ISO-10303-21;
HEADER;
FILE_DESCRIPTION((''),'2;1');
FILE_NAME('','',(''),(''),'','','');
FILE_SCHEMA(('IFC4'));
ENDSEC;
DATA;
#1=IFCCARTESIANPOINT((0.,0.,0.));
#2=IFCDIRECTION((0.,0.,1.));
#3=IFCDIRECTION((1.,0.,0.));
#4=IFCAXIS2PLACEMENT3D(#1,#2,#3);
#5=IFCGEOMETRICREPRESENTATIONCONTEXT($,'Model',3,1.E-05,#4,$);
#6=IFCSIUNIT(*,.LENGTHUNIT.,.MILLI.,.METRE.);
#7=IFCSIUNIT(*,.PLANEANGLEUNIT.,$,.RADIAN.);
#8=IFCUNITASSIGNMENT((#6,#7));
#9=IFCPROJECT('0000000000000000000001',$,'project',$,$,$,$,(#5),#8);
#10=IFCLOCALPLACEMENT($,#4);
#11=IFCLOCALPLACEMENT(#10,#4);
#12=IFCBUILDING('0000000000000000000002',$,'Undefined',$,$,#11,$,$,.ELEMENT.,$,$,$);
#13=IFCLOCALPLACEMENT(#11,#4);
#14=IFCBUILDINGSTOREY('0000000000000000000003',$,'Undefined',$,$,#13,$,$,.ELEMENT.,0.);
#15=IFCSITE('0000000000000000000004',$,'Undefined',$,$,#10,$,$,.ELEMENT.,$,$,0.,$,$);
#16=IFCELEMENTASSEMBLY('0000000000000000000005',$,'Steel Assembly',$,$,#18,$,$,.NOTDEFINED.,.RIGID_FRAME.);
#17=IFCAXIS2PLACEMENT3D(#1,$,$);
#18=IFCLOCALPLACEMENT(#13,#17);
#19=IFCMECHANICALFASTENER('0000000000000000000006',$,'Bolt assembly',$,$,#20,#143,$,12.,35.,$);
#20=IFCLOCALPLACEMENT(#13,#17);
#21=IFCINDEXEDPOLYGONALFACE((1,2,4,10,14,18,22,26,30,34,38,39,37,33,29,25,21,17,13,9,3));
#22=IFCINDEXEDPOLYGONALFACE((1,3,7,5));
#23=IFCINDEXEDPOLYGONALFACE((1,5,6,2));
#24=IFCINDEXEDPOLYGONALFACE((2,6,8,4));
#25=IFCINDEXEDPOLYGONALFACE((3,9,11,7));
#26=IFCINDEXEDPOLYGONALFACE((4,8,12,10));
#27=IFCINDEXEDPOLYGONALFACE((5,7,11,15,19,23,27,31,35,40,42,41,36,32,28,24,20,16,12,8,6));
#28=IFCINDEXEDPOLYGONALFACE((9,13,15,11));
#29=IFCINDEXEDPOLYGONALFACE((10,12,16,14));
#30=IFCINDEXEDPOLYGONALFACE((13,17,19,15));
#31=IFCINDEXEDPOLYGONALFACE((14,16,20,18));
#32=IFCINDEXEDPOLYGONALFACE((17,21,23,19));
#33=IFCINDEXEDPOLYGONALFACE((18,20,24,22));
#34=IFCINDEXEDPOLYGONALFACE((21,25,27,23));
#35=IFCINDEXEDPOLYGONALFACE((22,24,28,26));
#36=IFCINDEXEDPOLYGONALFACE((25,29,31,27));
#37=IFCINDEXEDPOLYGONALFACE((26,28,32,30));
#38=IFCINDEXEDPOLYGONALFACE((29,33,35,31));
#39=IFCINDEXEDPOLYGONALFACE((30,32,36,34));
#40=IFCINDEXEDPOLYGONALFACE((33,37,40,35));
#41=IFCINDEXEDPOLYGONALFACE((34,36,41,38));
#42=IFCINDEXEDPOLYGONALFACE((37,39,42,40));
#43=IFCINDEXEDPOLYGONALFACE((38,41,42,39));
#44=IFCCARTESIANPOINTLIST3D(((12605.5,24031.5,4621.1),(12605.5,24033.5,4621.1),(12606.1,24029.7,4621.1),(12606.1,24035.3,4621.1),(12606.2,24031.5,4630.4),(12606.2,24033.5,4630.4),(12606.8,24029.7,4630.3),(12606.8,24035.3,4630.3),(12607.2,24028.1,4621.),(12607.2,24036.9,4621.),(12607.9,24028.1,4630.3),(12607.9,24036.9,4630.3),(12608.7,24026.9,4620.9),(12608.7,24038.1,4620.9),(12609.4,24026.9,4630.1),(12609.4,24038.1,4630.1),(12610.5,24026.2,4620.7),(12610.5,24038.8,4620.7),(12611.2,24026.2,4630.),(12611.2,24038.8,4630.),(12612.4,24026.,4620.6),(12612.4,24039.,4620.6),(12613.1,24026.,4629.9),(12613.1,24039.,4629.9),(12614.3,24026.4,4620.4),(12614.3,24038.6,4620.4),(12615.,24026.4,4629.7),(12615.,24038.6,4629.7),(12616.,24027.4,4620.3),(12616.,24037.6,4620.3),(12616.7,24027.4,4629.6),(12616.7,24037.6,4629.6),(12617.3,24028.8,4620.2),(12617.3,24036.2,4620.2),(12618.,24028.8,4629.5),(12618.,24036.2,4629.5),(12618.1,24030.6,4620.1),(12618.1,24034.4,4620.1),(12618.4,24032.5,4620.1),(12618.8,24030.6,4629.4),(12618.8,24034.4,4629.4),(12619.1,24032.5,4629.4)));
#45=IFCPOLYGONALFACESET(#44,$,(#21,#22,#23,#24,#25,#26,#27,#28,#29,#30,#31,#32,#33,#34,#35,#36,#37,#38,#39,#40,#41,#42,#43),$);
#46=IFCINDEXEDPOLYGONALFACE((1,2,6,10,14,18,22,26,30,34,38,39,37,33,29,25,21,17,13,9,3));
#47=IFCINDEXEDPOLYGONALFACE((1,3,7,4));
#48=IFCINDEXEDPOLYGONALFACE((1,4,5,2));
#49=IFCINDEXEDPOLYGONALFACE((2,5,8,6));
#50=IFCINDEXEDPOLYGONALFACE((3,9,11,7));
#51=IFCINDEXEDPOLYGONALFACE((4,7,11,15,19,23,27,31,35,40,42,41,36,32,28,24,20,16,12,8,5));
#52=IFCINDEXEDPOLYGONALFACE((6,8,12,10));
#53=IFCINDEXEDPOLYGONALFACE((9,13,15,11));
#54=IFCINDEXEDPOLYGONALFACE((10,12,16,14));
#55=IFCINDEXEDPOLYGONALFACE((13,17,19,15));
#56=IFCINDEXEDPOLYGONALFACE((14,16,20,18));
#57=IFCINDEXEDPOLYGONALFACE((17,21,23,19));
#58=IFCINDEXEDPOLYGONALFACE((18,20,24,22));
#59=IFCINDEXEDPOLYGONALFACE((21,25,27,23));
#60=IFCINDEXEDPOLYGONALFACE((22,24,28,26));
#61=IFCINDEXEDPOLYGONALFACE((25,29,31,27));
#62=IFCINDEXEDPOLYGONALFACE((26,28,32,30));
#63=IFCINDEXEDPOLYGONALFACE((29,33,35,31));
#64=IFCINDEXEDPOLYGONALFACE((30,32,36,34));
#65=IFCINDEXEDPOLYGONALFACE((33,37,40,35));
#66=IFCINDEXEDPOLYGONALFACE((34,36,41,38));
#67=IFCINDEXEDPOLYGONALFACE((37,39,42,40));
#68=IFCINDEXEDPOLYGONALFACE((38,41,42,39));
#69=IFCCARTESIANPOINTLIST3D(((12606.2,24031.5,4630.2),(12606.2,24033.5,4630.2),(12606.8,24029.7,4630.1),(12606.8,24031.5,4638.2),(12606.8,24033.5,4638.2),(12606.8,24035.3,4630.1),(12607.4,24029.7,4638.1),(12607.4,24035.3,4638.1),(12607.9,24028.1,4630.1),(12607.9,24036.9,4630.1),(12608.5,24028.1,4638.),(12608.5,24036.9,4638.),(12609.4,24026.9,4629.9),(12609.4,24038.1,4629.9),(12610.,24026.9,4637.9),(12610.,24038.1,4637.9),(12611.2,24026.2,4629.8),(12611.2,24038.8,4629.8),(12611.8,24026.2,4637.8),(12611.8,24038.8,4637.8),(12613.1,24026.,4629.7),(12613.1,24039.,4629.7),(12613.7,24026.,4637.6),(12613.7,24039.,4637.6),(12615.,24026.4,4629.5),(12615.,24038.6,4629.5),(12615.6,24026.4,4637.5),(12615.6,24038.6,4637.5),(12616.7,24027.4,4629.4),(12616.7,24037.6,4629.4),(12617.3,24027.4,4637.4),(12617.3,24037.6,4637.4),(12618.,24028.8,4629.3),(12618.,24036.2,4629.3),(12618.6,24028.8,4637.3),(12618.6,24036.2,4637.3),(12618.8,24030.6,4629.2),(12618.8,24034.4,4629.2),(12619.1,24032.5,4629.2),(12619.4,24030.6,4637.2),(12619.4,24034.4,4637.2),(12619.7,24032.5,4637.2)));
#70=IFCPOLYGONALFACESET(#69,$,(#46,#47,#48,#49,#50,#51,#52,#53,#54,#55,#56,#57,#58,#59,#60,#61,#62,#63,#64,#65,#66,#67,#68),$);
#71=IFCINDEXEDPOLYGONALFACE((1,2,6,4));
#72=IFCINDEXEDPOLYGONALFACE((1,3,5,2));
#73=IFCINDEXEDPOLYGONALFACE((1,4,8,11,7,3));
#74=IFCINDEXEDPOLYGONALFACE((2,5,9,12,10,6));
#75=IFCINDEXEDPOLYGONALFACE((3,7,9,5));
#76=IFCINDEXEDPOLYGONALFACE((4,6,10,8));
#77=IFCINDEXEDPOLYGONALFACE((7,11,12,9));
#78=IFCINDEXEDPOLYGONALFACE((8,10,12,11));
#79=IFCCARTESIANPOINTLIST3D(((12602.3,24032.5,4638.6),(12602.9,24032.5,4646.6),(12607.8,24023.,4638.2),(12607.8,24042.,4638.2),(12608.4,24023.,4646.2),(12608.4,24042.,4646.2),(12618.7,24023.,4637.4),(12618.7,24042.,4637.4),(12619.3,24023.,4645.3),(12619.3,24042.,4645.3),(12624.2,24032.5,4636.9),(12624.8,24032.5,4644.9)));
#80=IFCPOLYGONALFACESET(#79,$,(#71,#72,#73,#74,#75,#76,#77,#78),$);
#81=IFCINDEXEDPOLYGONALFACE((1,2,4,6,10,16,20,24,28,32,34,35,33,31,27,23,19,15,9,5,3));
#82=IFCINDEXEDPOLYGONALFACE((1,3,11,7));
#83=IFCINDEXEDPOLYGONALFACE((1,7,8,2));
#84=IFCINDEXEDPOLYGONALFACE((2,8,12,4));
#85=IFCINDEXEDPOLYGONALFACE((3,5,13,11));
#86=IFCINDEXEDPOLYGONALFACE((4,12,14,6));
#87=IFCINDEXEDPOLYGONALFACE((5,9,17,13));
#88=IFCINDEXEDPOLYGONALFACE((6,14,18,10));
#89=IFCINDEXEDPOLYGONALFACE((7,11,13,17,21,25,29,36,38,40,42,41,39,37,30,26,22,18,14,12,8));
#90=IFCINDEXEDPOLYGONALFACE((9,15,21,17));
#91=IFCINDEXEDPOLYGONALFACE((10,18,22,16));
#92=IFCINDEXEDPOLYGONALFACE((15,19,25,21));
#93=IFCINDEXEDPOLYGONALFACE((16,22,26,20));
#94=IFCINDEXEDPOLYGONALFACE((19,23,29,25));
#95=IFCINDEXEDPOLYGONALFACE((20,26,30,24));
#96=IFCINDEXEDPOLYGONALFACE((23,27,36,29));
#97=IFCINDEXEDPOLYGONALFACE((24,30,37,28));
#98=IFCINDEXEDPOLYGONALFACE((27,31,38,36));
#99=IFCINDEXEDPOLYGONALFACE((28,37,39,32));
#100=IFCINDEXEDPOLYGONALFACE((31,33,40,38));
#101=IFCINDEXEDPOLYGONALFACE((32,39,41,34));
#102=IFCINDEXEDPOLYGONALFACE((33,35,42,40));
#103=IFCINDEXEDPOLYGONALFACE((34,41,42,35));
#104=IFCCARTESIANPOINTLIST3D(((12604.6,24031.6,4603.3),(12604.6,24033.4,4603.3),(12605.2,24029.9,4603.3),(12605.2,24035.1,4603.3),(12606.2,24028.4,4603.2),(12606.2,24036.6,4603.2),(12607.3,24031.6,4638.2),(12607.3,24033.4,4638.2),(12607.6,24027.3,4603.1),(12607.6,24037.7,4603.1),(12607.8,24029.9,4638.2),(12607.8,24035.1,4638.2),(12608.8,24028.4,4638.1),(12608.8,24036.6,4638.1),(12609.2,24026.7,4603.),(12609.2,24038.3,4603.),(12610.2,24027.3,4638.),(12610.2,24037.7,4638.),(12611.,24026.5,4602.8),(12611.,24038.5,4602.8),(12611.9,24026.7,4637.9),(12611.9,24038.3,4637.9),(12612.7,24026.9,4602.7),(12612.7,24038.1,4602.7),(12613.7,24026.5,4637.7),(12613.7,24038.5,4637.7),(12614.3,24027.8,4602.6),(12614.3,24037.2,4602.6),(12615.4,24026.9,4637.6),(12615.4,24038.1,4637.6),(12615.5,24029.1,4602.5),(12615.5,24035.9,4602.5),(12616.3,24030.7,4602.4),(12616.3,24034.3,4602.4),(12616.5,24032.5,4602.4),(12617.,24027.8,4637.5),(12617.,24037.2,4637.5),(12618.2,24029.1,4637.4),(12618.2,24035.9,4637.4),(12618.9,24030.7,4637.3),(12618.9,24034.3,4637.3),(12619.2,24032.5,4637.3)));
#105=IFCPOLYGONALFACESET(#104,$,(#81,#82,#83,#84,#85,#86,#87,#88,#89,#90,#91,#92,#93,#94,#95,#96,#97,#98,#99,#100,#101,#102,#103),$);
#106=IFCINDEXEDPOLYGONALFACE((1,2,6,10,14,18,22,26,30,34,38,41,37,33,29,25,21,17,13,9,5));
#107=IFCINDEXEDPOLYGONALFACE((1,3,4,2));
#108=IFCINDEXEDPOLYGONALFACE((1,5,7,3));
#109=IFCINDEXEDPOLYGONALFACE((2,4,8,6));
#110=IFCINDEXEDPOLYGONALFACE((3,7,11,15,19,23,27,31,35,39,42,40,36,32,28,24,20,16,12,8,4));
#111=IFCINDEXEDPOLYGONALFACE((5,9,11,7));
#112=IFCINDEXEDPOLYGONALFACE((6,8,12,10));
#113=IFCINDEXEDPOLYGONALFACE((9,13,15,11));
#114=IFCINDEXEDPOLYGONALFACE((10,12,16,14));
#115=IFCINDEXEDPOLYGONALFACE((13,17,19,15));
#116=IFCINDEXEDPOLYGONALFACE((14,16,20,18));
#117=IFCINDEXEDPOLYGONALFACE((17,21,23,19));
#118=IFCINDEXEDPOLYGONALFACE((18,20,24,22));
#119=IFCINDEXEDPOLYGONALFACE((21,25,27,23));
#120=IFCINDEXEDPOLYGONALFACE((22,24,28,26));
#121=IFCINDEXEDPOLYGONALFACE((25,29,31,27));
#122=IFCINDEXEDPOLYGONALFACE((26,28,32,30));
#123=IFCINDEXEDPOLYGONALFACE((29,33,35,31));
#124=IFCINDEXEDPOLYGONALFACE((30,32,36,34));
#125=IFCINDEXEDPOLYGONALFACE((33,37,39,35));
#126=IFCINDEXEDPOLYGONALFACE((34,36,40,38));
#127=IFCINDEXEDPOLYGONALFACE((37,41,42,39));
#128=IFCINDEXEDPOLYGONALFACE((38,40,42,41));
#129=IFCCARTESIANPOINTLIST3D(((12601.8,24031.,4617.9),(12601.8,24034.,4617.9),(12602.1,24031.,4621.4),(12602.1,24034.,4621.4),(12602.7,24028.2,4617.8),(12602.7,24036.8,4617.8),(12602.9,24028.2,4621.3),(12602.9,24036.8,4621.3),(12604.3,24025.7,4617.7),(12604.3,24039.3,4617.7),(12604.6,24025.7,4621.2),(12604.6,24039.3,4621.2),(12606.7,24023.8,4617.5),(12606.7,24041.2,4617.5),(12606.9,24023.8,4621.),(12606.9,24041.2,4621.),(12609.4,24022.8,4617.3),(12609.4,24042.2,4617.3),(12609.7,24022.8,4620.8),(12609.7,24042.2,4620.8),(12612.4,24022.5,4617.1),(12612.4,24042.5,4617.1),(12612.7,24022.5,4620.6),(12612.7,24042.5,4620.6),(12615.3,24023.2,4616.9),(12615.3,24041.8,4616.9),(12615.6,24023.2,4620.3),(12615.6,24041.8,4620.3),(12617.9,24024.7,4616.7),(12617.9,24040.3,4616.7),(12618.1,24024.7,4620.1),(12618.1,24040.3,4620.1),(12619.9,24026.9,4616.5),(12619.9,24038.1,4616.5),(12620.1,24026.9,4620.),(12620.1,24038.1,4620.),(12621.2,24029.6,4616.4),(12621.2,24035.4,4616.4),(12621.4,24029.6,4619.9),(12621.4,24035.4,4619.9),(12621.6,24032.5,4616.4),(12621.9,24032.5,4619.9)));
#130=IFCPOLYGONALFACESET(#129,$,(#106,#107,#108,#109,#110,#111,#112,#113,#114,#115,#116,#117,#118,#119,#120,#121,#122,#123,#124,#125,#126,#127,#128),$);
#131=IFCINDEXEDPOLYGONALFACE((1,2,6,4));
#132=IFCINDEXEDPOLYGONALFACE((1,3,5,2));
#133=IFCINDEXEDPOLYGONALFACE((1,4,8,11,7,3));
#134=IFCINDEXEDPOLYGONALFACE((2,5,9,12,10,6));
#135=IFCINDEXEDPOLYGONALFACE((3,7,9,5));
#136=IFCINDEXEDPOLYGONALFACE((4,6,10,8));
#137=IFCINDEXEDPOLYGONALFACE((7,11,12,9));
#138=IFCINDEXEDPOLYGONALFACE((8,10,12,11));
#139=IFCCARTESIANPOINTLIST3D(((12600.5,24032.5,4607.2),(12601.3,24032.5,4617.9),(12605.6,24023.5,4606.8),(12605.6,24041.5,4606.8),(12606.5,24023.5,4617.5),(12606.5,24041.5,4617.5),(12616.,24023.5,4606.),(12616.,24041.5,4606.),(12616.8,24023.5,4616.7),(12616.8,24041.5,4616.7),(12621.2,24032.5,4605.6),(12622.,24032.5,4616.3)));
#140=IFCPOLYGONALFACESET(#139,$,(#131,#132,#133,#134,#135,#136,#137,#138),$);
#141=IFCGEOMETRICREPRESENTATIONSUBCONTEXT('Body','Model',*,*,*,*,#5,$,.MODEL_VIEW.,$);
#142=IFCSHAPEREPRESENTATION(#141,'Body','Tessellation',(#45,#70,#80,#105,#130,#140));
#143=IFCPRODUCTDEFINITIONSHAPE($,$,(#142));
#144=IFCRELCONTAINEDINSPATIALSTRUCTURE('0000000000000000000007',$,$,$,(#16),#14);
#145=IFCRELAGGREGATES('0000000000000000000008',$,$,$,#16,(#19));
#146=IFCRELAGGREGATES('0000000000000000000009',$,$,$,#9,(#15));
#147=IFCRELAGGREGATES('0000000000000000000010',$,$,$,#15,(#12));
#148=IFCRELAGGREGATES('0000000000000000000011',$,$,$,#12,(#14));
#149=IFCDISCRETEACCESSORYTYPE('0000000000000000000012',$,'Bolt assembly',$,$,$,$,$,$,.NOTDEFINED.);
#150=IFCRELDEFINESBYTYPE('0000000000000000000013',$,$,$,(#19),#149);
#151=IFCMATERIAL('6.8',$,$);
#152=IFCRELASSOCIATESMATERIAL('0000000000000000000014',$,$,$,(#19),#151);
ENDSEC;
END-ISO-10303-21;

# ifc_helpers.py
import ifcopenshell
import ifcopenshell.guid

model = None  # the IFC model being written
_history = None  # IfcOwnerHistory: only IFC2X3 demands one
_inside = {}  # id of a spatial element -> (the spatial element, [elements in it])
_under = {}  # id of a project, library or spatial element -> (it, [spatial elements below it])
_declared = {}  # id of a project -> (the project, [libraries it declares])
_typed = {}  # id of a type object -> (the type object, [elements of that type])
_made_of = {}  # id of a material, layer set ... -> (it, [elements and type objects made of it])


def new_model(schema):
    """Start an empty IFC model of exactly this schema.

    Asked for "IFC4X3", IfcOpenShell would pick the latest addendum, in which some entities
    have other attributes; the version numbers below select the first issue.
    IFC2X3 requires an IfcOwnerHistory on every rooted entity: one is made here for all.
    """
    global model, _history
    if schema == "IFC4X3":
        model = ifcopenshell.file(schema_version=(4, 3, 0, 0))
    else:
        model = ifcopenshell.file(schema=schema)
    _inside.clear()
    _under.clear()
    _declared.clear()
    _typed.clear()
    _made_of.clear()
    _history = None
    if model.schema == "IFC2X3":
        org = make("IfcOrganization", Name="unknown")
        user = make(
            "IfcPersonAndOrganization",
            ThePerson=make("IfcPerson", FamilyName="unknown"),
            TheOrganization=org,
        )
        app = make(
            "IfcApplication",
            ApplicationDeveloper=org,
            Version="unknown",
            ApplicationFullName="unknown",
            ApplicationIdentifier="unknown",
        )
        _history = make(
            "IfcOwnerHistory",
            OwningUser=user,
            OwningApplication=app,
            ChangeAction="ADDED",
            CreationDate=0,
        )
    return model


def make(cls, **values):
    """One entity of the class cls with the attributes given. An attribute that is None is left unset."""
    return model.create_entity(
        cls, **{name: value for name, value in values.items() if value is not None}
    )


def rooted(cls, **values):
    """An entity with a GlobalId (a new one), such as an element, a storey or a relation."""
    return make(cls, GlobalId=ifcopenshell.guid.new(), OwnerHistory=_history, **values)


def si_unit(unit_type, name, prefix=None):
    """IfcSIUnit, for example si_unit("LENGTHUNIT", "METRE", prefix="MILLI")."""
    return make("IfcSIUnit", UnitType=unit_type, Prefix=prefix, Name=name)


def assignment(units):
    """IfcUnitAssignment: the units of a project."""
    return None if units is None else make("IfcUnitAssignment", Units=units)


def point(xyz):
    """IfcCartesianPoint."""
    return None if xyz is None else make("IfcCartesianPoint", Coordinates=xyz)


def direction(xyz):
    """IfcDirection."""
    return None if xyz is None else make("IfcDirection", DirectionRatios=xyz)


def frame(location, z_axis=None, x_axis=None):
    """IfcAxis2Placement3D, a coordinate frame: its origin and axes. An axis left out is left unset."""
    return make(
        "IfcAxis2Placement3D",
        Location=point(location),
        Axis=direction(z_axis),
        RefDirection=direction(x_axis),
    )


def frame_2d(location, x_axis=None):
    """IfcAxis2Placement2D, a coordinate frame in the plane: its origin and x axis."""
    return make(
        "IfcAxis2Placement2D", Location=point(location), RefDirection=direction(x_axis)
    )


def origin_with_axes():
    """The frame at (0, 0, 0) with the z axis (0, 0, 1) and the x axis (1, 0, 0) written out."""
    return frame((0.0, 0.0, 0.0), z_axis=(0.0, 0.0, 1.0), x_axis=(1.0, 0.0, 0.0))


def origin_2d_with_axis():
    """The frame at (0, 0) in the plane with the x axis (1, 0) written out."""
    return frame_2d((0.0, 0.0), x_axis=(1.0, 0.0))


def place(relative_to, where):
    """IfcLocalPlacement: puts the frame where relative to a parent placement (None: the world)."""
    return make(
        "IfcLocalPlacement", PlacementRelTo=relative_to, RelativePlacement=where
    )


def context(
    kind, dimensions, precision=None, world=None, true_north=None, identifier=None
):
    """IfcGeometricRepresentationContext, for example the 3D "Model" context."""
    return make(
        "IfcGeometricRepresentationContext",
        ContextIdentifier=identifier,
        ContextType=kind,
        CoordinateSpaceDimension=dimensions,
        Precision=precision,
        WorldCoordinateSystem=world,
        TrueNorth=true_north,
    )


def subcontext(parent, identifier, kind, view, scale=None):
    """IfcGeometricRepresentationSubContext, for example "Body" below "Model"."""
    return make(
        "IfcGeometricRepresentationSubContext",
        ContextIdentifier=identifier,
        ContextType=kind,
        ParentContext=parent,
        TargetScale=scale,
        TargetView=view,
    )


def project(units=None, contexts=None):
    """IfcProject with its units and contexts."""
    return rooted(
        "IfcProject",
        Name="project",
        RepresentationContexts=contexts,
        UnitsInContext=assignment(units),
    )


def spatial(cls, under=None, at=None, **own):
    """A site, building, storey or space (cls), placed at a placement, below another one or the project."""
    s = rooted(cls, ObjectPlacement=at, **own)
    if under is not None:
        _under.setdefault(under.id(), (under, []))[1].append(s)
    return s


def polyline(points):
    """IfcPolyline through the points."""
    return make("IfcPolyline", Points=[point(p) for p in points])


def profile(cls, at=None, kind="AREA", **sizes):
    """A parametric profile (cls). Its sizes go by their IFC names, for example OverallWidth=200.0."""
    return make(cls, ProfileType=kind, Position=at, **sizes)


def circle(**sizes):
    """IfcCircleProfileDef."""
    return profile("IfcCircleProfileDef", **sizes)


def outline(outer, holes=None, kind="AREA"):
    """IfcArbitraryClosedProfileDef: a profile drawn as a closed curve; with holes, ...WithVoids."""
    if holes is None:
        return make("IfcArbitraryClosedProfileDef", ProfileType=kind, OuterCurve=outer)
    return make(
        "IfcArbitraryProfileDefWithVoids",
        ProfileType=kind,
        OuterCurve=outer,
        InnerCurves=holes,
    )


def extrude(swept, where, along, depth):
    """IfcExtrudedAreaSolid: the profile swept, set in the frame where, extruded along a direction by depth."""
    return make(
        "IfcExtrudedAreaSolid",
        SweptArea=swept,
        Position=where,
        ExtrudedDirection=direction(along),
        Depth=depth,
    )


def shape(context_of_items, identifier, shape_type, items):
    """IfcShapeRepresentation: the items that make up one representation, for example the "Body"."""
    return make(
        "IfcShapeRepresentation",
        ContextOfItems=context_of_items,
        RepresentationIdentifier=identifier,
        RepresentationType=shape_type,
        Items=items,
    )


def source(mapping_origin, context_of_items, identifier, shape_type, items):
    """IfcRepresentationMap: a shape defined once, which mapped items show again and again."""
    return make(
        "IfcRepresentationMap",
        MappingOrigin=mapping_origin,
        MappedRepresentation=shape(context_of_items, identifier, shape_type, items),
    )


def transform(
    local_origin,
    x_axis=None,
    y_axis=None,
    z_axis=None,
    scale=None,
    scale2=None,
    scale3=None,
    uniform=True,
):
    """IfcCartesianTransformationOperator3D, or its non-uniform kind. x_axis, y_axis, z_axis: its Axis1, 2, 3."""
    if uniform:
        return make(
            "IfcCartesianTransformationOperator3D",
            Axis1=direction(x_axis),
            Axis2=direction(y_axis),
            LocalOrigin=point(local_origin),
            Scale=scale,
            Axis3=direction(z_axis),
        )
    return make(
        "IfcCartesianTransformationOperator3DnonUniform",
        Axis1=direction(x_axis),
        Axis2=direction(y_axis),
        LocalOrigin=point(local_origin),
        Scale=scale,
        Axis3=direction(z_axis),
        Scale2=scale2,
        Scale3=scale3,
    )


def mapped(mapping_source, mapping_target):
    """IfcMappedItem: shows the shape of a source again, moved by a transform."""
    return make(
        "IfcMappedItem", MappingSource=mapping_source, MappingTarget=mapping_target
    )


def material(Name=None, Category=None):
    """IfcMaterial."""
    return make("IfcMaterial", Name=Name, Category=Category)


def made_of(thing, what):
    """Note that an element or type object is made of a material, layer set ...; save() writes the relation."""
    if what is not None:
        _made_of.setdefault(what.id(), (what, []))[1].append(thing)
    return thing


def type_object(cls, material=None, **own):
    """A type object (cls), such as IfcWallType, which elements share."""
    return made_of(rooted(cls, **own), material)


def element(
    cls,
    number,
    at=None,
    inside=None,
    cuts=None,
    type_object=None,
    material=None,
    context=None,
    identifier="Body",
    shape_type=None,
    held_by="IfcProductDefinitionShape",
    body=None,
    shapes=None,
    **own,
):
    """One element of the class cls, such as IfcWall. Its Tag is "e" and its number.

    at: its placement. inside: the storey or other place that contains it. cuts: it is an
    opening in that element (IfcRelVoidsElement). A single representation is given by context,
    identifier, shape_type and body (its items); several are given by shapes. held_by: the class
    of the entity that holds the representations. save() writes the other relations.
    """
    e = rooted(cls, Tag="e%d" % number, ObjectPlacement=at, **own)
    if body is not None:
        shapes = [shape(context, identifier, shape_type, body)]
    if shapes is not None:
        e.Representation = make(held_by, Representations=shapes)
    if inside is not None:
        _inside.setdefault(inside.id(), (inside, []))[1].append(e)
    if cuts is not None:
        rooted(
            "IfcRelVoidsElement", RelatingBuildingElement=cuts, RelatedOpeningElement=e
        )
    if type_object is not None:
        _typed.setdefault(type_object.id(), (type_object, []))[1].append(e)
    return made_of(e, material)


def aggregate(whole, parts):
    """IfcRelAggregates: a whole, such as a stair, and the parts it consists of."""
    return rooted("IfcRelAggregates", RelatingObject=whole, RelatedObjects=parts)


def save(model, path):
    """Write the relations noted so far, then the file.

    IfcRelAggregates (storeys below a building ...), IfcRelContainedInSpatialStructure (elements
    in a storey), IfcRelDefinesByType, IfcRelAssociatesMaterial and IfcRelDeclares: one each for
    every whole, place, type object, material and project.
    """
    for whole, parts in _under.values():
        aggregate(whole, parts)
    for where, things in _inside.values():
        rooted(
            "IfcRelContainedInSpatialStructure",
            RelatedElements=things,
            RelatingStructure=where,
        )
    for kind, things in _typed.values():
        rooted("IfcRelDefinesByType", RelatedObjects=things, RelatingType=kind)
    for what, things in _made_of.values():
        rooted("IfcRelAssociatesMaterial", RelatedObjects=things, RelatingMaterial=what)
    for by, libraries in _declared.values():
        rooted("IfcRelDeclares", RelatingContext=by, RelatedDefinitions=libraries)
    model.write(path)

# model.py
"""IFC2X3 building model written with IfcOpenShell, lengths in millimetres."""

from ifc_helpers import new_model, si_unit, frame, origin_with_axes, origin_2d_with_axis, place, context, subcontext, project, spatial, polyline, circle, outline, extrude, source, transform, mapped, material, type_object, element, aggregate, save


model = new_model("IFC2X3")

# Units and contexts
model_context = context("Model", 3, precision=1e-05, world=origin_with_axes())
body_context = subcontext(model_context, "Body", "Model", "MODEL_VIEW")
ifc_project = project(units=[si_unit("LENGTHUNIT", "METRE", prefix="MILLI"), si_unit("PLANEANGLEUNIT", "RADIAN")], contexts=[model_context])

# Site, building, storey
site_placement = place(None, origin_with_axes())
site = spatial("IfcSite", under=ifc_project, at=site_placement, Name="Undefined", CompositionType="ELEMENT", RefElevation=0.0)
building_placement = place(site_placement, origin_with_axes())
building = spatial("IfcBuilding", under=site, at=building_placement, Name="Undefined", CompositionType="ELEMENT")
storey_placement = place(building_placement, origin_with_axes())
storey = spatial("IfcBuildingStorey", under=building, at=storey_placement, Name="Undefined", CompositionType="ELEMENT", Elevation=0.0)

# Shared definitions
ifc_material_1 = material(Name="6.8")
discrete_accessory_type_1 = type_object("IfcDiscreteAccessoryType", Name="Bolt assembly")

# Element assembly, mechanical fastener
assembly_1_placement = place(storey_placement, origin_with_axes())
assembly_1 = element("IfcElementAssembly", 1, at=assembly_1_placement, inside=storey, Name="Steel Assembly", AssemblyPlace="NOTDEFINED", PredefinedType="RIGID_FRAME")
shared_shape_1 = source(origin_with_axes(), body_context, "Body", "SweptSolid", [
    extrude(circle(Radius=6.5, at=origin_2d_with_axis()), frame((0.0, -0.1, 0.0), z_axis=(0.0, 1.0, 0.0), x_axis=(1.0, 0.0, 0.0)), (0.0, 0.0, 1.0), 9.3),
    extrude(circle(Radius=6.5, at=origin_2d_with_axis()), frame((0.0, -7.9, 0.0), z_axis=(0.0, 1.0, 0.0), x_axis=(1.0, 0.0, 0.0)), (0.0, 0.0, 1.0), 8.0),
    extrude(outline(polyline([(11.0, 0.0), (5.5, 9.5), (-5.5, 9.5), (-11.0, 0.0), (-5.5, -9.5), (5.5, -9.5), (11.0, 0.0)])), frame((0.0, -16.0, 0.0), z_axis=(0.0, 1.0, 0.0), x_axis=(1.0, 0.0, 0.0)), (0.0, 0.0, 1.0), 8.0),
    extrude(circle(Radius=6.0, at=origin_2d_with_axis()), frame((0.0, -8.0, 0.0), z_axis=(0.0, 1.0, 0.0), x_axis=(1.0, 0.0, 0.0)), (0.0, 0.0, 1.0), 35.0),
    extrude(circle(Radius=10.0, at=origin_2d_with_axis()), frame((0.0, 9.2, 0.0), z_axis=(0.0, 1.0, 0.0), x_axis=(1.0, 0.0, 0.0)), (0.0, 0.0, 1.0), 3.5),
    extrude(outline(polyline([(10.4, 0.0), (5.2, 9.0), (-5.2, 9.0), (-10.4, 0.0), (-5.2, -9.0), (5.2, -9.0), (10.4, 0.0)])), frame((0.0, 12.7, 0.0), z_axis=(0.0, 1.0, 0.0), x_axis=(1.0, 0.0, 0.0)), (0.0, 0.0, 1.0), 10.8),
])
mechanical_fastener_1_placement = place(assembly_1_placement, frame((12612.6, 24032.5, 4629.8), z_axis=(0.0, 1.0, 0.0), x_axis=(0.997054, 0.0, -0.076696)))
mechanical_fastener_1 = element("IfcMechanicalFastener", 2, at=mechanical_fastener_1_placement, type_object=discrete_accessory_type_1, material=ifc_material_1, Name="Bolt assembly", NominalDiameter=12.0, NominalLength=35.0, context=body_context, shape_type="MappedRepresentation", body=[
    mapped(shared_shape_1, transform((0.0, 0.0, 0.0))),
])
aggregate(assembly_1, [mechanical_fastener_1])

save(model, "model.ifc")
